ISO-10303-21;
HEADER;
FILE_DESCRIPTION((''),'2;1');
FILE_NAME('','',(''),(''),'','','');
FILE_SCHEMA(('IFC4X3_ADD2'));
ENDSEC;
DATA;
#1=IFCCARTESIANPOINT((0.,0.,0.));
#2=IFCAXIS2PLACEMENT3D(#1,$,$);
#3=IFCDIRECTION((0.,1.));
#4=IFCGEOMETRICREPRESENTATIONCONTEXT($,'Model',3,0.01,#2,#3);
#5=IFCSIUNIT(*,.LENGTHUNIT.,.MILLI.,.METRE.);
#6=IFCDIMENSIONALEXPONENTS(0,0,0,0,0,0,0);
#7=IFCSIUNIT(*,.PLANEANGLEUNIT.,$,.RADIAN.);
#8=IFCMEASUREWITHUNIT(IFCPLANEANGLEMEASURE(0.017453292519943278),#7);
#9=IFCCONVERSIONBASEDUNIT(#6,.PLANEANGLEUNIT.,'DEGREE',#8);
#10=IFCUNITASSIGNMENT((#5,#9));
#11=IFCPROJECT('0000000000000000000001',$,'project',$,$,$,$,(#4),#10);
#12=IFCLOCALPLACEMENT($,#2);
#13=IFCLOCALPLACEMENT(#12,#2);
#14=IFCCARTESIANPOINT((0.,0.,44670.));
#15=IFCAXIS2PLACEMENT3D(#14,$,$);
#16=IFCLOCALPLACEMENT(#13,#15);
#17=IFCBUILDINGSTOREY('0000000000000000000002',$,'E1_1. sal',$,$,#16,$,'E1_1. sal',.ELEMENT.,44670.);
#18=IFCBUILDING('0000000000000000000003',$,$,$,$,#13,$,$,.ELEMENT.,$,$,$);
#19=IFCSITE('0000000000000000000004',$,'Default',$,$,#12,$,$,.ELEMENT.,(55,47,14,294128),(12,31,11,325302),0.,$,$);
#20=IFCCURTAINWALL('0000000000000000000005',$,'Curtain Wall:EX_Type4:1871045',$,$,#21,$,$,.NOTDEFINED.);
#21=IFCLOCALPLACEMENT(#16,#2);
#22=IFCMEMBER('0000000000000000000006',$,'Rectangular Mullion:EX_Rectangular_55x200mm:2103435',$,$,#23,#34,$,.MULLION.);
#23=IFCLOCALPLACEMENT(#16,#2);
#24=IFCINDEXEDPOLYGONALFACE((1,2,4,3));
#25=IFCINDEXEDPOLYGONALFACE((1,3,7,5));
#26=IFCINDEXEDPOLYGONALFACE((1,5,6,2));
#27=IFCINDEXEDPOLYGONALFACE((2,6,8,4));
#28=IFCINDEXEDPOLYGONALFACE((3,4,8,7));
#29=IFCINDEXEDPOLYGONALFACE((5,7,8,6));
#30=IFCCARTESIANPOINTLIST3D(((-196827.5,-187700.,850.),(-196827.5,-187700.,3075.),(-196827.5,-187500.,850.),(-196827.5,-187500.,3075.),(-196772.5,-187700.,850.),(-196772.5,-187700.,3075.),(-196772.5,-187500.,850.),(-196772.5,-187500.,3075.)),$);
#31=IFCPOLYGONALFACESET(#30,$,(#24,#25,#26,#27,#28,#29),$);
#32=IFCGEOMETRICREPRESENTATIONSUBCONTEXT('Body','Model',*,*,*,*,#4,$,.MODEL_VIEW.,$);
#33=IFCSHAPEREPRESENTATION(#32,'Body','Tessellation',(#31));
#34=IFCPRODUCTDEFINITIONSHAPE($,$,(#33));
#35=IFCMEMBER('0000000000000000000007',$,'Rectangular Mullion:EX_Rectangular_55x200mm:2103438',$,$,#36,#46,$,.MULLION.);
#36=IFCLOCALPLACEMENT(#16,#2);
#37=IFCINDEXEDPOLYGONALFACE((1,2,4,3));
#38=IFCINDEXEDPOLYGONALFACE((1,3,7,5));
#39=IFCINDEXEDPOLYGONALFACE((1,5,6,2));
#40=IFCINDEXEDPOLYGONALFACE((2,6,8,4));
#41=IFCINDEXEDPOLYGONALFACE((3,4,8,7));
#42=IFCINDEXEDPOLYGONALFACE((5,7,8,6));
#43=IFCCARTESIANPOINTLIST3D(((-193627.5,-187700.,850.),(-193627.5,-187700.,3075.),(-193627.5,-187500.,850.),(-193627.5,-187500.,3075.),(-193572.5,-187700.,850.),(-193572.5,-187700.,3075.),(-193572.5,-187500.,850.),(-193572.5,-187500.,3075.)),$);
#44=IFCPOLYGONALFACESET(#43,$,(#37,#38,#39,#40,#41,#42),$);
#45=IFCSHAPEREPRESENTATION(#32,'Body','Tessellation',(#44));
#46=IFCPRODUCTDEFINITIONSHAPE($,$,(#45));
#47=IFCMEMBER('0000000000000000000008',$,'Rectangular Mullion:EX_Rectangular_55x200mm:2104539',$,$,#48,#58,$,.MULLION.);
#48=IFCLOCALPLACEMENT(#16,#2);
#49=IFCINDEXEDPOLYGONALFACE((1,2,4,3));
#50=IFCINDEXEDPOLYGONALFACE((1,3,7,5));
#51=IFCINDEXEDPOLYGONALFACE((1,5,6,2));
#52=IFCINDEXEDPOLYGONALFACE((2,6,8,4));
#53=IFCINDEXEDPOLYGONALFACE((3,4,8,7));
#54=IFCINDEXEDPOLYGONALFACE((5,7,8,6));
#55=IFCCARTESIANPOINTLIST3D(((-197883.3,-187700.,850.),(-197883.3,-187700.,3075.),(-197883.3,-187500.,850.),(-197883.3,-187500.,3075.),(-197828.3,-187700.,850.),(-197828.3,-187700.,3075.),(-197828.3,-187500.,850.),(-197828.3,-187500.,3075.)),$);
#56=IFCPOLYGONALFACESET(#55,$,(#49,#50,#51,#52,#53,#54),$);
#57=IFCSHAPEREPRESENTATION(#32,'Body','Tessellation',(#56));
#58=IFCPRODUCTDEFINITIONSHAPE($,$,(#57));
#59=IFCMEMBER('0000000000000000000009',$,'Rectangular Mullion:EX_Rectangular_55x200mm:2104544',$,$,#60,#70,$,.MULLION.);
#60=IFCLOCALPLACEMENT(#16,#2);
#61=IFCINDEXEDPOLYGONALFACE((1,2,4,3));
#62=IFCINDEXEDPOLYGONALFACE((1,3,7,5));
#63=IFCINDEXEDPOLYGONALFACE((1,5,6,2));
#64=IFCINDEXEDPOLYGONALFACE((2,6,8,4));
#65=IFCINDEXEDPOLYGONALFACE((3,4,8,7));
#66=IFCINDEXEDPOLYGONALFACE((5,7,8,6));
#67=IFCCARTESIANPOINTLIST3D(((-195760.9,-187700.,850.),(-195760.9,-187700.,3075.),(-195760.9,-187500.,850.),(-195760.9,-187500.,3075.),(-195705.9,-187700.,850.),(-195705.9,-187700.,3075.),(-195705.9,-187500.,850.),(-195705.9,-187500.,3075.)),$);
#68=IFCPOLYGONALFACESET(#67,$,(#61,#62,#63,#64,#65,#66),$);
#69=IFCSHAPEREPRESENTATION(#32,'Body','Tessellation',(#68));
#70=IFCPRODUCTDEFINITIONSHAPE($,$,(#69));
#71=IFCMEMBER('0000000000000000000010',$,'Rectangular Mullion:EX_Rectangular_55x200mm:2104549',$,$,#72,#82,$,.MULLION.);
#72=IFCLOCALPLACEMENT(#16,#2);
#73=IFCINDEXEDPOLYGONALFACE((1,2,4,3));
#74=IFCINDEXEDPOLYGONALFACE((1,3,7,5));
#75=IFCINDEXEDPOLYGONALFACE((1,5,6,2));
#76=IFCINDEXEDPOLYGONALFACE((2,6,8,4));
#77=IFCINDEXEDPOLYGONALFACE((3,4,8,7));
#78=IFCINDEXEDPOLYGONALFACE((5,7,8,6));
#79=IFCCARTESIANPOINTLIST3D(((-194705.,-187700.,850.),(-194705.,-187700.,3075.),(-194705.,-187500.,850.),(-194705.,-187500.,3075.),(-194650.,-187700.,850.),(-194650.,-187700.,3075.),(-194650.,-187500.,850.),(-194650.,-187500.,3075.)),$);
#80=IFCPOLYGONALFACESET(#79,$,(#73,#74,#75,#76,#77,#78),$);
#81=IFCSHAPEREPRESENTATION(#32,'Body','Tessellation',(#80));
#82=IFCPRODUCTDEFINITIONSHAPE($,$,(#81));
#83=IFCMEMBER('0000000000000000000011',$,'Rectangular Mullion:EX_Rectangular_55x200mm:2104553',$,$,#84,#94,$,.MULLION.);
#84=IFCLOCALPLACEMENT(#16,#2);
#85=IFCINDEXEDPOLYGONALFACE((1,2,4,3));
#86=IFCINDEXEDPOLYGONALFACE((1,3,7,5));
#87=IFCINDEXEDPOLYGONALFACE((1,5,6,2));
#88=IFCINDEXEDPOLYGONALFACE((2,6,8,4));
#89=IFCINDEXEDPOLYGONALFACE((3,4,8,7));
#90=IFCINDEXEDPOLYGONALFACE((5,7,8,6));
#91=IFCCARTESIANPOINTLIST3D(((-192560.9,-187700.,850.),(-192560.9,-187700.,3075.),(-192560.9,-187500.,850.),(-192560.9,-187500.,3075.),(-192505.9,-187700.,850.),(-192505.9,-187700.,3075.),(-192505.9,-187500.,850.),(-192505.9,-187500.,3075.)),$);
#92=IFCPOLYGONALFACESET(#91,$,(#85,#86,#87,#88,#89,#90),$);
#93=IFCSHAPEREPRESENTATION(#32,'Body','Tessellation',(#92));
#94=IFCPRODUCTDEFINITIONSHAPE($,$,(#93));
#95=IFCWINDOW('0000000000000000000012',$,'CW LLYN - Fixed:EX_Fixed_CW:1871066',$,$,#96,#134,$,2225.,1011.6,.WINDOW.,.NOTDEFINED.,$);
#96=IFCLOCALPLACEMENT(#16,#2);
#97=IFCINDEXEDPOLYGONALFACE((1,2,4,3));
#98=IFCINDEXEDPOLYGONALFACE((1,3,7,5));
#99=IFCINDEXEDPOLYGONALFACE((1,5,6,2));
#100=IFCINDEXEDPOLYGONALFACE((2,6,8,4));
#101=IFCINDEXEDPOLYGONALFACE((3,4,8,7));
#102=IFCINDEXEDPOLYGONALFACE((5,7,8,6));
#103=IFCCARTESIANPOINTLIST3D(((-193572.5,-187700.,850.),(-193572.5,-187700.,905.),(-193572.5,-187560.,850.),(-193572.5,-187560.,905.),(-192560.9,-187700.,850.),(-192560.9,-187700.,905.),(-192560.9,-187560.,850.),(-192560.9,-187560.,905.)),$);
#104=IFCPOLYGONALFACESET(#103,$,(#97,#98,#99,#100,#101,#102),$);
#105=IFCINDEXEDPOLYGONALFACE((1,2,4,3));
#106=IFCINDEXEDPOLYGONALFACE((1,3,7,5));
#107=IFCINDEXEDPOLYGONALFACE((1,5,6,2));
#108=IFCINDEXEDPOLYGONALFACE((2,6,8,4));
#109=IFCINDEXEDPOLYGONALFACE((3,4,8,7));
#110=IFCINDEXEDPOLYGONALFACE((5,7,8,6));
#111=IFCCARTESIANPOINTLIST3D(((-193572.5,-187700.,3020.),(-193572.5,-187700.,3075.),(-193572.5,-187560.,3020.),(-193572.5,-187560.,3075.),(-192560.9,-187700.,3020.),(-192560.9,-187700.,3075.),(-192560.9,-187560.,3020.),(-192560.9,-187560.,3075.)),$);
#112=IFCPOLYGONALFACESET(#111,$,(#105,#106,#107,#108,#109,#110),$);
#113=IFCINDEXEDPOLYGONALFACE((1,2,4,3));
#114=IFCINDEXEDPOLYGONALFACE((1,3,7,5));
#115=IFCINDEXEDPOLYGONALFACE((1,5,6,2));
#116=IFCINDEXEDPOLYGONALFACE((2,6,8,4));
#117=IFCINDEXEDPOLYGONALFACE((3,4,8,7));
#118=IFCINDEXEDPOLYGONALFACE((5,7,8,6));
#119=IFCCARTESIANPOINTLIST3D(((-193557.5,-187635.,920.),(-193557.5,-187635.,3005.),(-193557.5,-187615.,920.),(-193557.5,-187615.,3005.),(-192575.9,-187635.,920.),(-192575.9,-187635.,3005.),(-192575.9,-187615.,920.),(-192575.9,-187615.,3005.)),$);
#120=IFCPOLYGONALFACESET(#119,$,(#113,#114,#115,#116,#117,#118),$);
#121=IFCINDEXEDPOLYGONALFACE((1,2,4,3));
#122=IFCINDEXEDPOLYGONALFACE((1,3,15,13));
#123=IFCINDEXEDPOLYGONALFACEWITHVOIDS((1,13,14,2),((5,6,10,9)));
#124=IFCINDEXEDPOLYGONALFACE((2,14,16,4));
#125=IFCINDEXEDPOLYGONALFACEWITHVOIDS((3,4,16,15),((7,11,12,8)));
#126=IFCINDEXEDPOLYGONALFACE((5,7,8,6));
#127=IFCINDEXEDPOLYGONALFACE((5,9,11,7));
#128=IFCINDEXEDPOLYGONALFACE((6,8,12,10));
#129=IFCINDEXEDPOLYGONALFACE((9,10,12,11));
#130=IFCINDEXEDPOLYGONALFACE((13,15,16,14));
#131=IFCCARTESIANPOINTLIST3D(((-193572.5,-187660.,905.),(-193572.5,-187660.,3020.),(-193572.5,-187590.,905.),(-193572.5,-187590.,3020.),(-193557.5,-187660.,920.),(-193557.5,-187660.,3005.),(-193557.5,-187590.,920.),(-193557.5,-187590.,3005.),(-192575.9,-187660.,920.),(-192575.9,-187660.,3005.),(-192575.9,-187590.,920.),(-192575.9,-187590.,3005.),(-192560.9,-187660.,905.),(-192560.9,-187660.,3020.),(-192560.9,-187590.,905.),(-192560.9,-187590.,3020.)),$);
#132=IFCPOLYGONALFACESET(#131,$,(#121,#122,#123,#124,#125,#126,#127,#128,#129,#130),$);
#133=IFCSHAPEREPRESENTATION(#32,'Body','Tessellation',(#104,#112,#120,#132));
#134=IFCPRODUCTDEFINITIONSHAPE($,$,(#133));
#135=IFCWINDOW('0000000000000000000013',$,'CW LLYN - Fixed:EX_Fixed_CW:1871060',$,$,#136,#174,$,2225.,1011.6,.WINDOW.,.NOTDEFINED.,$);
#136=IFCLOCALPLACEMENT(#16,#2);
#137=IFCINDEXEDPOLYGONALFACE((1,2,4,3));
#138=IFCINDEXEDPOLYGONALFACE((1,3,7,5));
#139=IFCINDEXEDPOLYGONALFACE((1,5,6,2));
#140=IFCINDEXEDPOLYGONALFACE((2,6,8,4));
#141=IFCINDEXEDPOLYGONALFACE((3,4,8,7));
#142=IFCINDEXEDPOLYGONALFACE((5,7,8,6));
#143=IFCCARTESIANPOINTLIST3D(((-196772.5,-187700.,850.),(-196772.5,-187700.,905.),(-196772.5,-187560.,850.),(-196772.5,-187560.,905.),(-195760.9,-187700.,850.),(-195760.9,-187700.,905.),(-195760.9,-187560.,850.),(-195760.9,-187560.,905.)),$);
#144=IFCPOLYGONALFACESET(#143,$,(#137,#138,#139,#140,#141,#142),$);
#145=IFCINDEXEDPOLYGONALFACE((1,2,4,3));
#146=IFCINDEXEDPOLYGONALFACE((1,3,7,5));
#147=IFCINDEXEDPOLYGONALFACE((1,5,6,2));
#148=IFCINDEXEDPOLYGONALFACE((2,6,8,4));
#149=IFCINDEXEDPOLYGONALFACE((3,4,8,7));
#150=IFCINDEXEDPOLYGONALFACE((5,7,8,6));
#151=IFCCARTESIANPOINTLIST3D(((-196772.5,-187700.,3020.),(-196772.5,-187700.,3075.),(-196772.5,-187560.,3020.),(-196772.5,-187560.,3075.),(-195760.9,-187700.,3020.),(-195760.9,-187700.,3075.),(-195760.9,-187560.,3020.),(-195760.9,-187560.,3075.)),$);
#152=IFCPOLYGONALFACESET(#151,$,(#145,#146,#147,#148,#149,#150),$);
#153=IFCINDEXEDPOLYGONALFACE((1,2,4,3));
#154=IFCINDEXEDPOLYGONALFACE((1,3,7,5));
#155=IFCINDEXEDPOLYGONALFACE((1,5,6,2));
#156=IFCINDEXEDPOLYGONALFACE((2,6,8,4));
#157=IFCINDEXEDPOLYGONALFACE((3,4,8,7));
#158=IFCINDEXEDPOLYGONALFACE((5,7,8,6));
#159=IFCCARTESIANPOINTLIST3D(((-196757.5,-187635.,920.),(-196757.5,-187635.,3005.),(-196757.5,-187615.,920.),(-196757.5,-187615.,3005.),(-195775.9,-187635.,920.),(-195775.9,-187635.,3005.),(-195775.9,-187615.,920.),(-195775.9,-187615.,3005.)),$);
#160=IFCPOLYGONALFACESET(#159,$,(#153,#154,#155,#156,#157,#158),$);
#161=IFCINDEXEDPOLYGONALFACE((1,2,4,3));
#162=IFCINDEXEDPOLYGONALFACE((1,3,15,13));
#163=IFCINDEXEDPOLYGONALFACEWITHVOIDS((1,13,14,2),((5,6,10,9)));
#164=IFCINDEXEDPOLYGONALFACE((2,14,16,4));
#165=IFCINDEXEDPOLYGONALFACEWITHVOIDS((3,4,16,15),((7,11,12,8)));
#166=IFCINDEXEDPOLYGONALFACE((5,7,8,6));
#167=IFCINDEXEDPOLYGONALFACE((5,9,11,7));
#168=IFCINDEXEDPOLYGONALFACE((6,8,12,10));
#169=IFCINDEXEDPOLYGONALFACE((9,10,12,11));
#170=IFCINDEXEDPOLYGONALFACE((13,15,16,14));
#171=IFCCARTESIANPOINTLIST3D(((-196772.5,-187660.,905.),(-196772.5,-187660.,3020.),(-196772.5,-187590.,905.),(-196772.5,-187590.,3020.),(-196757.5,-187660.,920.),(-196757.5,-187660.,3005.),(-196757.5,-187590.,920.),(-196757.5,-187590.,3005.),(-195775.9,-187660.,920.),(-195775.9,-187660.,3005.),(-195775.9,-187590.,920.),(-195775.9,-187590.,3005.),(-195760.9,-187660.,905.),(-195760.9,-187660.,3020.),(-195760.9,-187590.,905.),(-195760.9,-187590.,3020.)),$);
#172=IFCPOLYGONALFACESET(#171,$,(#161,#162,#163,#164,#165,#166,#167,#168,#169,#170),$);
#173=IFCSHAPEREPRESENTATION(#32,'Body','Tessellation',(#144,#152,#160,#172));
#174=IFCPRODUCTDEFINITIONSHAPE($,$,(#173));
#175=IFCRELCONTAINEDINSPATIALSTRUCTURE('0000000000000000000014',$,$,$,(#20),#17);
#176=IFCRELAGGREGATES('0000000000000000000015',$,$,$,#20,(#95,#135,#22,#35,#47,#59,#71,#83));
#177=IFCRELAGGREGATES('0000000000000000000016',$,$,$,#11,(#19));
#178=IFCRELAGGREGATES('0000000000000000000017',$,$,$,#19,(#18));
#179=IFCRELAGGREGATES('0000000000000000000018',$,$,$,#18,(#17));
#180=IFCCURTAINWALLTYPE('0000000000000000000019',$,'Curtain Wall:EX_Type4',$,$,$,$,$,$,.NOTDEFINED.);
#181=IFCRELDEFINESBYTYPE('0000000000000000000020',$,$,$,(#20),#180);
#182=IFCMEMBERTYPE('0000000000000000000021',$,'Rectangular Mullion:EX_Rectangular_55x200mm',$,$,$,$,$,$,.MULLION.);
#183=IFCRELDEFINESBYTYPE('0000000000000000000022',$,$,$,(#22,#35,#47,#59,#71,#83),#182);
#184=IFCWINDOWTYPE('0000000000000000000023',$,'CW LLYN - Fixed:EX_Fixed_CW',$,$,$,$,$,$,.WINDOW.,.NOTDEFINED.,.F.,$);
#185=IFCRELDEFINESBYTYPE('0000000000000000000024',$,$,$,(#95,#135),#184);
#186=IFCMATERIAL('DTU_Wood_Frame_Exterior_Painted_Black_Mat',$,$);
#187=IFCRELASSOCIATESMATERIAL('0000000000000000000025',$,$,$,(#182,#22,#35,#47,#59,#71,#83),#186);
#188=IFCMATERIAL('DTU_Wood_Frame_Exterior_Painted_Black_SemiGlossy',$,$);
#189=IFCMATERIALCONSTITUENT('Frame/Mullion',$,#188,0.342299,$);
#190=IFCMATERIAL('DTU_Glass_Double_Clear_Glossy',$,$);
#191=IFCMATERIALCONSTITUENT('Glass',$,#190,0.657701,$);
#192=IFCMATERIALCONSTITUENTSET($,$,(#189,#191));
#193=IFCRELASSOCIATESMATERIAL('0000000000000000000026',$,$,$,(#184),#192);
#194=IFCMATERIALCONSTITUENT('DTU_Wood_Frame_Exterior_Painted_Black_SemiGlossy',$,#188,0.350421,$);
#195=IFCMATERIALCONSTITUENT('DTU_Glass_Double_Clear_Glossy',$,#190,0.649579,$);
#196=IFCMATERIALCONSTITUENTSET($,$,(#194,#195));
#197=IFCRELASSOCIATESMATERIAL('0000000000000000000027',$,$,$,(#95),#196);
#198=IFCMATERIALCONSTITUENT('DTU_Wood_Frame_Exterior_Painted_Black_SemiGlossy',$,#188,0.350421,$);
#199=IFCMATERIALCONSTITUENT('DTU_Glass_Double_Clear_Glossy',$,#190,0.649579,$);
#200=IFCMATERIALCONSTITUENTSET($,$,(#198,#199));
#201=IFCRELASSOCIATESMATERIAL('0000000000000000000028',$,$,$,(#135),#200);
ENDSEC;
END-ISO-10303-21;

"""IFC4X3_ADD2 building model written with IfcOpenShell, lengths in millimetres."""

from ifc_helpers import new_model, entity, si_unit, converted_unit, direction, frame, frame_2d, origin, origin_2d_with_axis, place, context, subcontext, project, spatial, polyline, rectangle, outline, extrude, source, transform, mapped, material, constituent, constituent_set, material_profile, profile_set, profile_usage, type_object, type_shapes, element, aggregate, save


model = new_model("IFC4X3_ADD2")

# Units and contexts
model_context = context("Model", 3, precision=0.01, world=origin(), true_north=direction((0.0, 1.0)))
body_context = subcontext(model_context, "Body", "Model", "MODEL_VIEW")
ifc_project = project(units=[si_unit("LENGTHUNIT", "METRE", prefix="MILLI"), converted_unit("PLANEANGLEUNIT", "DEGREE", entity("IfcPlaneAngleMeasure", 0.017453292519943278), si_unit("PLANEANGLEUNIT", "RADIAN"), dimensions=[0, 0, 0, 0, 0, 0, 0])], contexts=[model_context])

# Site, building, storey
site_placement = place(None, origin())
site = spatial("IfcSite", under=ifc_project, at=site_placement, Name="Default", CompositionType="ELEMENT", RefLatitude=(55, 47, 14, 294128), RefLongitude=(12, 31, 11, 325302), RefElevation=0.0)
building_placement = place(site_placement, origin())
building = spatial("IfcBuilding", under=site, at=building_placement, CompositionType="ELEMENT")
storey_placement = place(building_placement, frame((0.0, 0.0, 44670.0)))
storey = spatial("IfcBuildingStorey", under=building, at=storey_placement, Name="E1_1. sal", LongName="E1_1. sal", CompositionType="ELEMENT", Elevation=44670.0)

# Curtain wall, members, windows
curtain_wall_type = type_object("IfcCurtainWallType", Name="Curtain Wall:EX_Type4", PredefinedType="NOTDEFINED")
curtain_wall_placement = place(storey_placement, frame((0.0, 0.0, -44670.0)))
curtain_wall = element("IfcCurtainWall", 1, at=curtain_wall_placement, inside=storey, type_object=curtain_wall_type, Name="Curtain Wall:EX_Type4:1871045", PredefinedType="NOTDEFINED")
ifc_material_1 = material(Name="DTU_Wood_Frame_Exterior_Painted_Black_Mat")
ifc_material_profile = material_profile(ifc_material_1, rectangle(XDim=55.0, YDim=200.0, at=origin_2d_with_axis()), Name="EX_Rectangular_55x200mm")
ifc_profile_set = profile_set([ifc_material_profile], Name="EX_Rectangular_55x200mm")
ifc_profile_usage = profile_usage(ifc_profile_set)
member_type = type_object("IfcMemberType", Name="Rectangular Mullion:EX_Rectangular_55x200mm", PredefinedType="MULLION", material=ifc_profile_set)
shared_shape_1 = source(origin(), body_context, "Body", "SweptSolid", [
    extrude(rectangle(XDim=55.0, YDim=200.0, at=origin_2d_with_axis()), frame((0.0, -100.0, -2225.0), z_axis=(0.0, 0.0, 1.0), x_axis=(-1.0, 0.0, 0.0)), (0.0, 0.0, 1.0), 2225.0),
])
type_shapes(member_type, [shared_shape_1])
member_1_placement = place(curtain_wall_placement, frame((-196800.0, -187500.0, 45520.0), z_axis=(0.0, 0.0, -1.0), x_axis=(-1.0, 0.0, 0.0)))
member_1 = element("IfcMember", 2, at=member_1_placement, type_object=member_type, material=ifc_profile_usage, Name="Rectangular Mullion:EX_Rectangular_55x200mm:2103435", PredefinedType="MULLION", context=body_context, shape_type="MappedRepresentation", body=[
    mapped(shared_shape_1, transform((0.0, 0.0, 0.0), scale=1.0)),
])
member_2_placement = place(curtain_wall_placement, frame((-193600.0, -187500.0, 45520.0), z_axis=(0.0, 0.0, -1.0), x_axis=(-1.0, 0.0, 0.0)))
member_2 = element("IfcMember", 3, at=member_2_placement, type_object=member_type, material=ifc_profile_usage, Name="Rectangular Mullion:EX_Rectangular_55x200mm:2103438", PredefinedType="MULLION", context=body_context, shape_type="MappedRepresentation", body=[
    mapped(shared_shape_1, transform((0.0, 0.0, 0.0), scale=1.0)),
])
member_3_placement = place(curtain_wall_placement, frame((-197855.8, -187500.0, 45520.0), z_axis=(0.0, 0.0, -1.0), x_axis=(-1.0, 0.0, 0.0)))
member_3 = element("IfcMember", 4, at=member_3_placement, type_object=member_type, material=ifc_profile_usage, Name="Rectangular Mullion:EX_Rectangular_55x200mm:2104539", PredefinedType="MULLION", context=body_context, shape_type="MappedRepresentation", body=[
    mapped(shared_shape_1, transform((0.0, 0.0, 0.0), scale=1.0)),
])
member_4_placement = place(curtain_wall_placement, frame((-195733.4, -187500.0, 45520.0), z_axis=(0.0, 0.0, -1.0), x_axis=(-1.0, 0.0, 0.0)))
member_4 = element("IfcMember", 5, at=member_4_placement, type_object=member_type, material=ifc_profile_usage, Name="Rectangular Mullion:EX_Rectangular_55x200mm:2104544", PredefinedType="MULLION", context=body_context, shape_type="MappedRepresentation", body=[
    mapped(shared_shape_1, transform((0.0, 0.0, 0.0), scale=1.0)),
])
member_5_placement = place(curtain_wall_placement, frame((-194677.5, -187500.0, 45520.0), z_axis=(0.0, 0.0, -1.0), x_axis=(-1.0, 0.0, 0.0)))
member_5 = element("IfcMember", 6, at=member_5_placement, type_object=member_type, material=ifc_profile_usage, Name="Rectangular Mullion:EX_Rectangular_55x200mm:2104549", PredefinedType="MULLION", context=body_context, shape_type="MappedRepresentation", body=[
    mapped(shared_shape_1, transform((0.0, 0.0, 0.0), scale=1.0)),
])
member_6_placement = place(curtain_wall_placement, frame((-192533.4, -187500.0, 45520.0), z_axis=(0.0, 0.0, -1.0), x_axis=(-1.0, 0.0, 0.0)))
member_6 = element("IfcMember", 7, at=member_6_placement, type_object=member_type, material=ifc_profile_usage, Name="Rectangular Mullion:EX_Rectangular_55x200mm:2104553", PredefinedType="MULLION", context=body_context, shape_type="MappedRepresentation", body=[
    mapped(shared_shape_1, transform((0.0, 0.0, 0.0), scale=1.0)),
])
ifc_material_2 = material(Name="DTU_Wood_Frame_Exterior_Painted_Black_SemiGlossy")
ifc_constituent_1 = constituent(ifc_material_2, Name="DTU_Wood_Frame_Exterior_Painted_Black_SemiGlossy", fraction=0.350421)
ifc_material_3 = material(Name="DTU_Glass_Double_Clear_Glossy")
ifc_constituent_2 = constituent(ifc_material_3, Name="DTU_Glass_Double_Clear_Glossy", fraction=0.649579)
ifc_constituent_set_1 = constituent_set(constituents=[ifc_constituent_1, ifc_constituent_2])
ifc_constituent_3 = constituent(ifc_material_2, Name="Frame/Mullion", fraction=0.342299)
ifc_constituent_4 = constituent(ifc_material_3, Name="Glass", fraction=0.657701)
ifc_constituent_set_2 = constituent_set(constituents=[ifc_constituent_3, ifc_constituent_4])
window_type_1 = type_object("IfcWindowType", Name="CW LLYN - Fixed:EX_Fixed_CW", ParameterTakesPrecedence=False, PartitioningType="NOTDEFINED", PredefinedType="WINDOW", material=ifc_constituent_set_2)
shared_shape_2 = source(origin(), body_context, "Body", "SweptSolid", [
    extrude(rectangle(XDim=140.0, YDim=1011.6, at=origin_2d_with_axis()), frame((0.0, -130.0, 0.0), z_axis=(0.0, 0.0, 1.0), x_axis=(0.0, -1.0, 0.0)), (0.0, 0.0, 1.0), 55.0),
    extrude(rectangle(XDim=140.0, YDim=1011.6, at=frame_2d((0.0, 0.0), x_axis=(1.0, 0.0))), frame((0.0, -130.0, 2170.0), z_axis=(0.0, 0.0, 1.0), x_axis=(0.0, -1.0, 0.0)), (0.0, 0.0, 1.0), 55.0),
    extrude(rectangle(XDim=981.6, YDim=20.0, at=frame_2d((0.0, 0.0), x_axis=(1.0, 0.0))), frame((0.0, -125.0, 70.0), z_axis=(0.0, 0.0, 1.0), x_axis=(-1.0, 0.0, 0.0)), (0.0, 0.0, 1.0), 2085.0),
    extrude(outline(polyline([(-1057.5, -505.8), (1057.5, -505.8), (1057.5, 505.8), (-1057.5, 505.8), (-1057.5, -505.8)]), holes=[polyline([(-1042.5, 490.8), (1042.5, 490.8), (1042.5, -490.8), (-1042.5, -490.8), (-1042.5, 490.8)])]), frame((0.0, -90.0, 1112.5), z_axis=(0.0, -1.0, 0.0), x_axis=(0.0, 0.0, 1.0)), (0.0, 0.0, 1.0), 70.0),
])
type_shapes(window_type_1, [shared_shape_2])
window_1_placement = place(curtain_wall_placement, frame((-193066.7, -187500.0, 45520.0)))
window_1 = element("IfcWindow", 8, at=window_1_placement, type_object=window_type_1, material=ifc_constituent_set_1, Name="CW LLYN - Fixed:EX_Fixed_CW:1871066", OverallHeight=2225.0, OverallWidth=1011.6, PartitioningType="NOTDEFINED", PredefinedType="WINDOW", context=body_context, shape_type="MappedRepresentation", body=[
    mapped(shared_shape_2, transform((0.0, 0.0, 0.0), scale=1.0)),
])
ifc_constituent_5 = constituent(ifc_material_2, Name="DTU_Wood_Frame_Exterior_Painted_Black_SemiGlossy", fraction=0.350421)
ifc_constituent_6 = constituent(ifc_material_3, Name="DTU_Glass_Double_Clear_Glossy", fraction=0.649579)
ifc_constituent_set_3 = constituent_set(constituents=[ifc_constituent_5, ifc_constituent_6])
window_2_placement = place(curtain_wall_placement, frame((-196266.7, -187500.0, 45520.0)))
window_2 = element("IfcWindow", 9, at=window_2_placement, type_object=window_type_1, material=ifc_constituent_set_3, Name="CW LLYN - Fixed:EX_Fixed_CW:1871060", OverallHeight=2225.0, OverallWidth=1011.6, PartitioningType="NOTDEFINED", PredefinedType="WINDOW", context=body_context, shape_type="MappedRepresentation", body=[
    mapped(shared_shape_2, transform((0.0, 0.0, 0.0), scale=1.0)),
])
aggregate(curtain_wall, [window_1, window_2, member_1, member_2, member_3, member_4, member_5, member_6])

save(model, "model.ifc")
